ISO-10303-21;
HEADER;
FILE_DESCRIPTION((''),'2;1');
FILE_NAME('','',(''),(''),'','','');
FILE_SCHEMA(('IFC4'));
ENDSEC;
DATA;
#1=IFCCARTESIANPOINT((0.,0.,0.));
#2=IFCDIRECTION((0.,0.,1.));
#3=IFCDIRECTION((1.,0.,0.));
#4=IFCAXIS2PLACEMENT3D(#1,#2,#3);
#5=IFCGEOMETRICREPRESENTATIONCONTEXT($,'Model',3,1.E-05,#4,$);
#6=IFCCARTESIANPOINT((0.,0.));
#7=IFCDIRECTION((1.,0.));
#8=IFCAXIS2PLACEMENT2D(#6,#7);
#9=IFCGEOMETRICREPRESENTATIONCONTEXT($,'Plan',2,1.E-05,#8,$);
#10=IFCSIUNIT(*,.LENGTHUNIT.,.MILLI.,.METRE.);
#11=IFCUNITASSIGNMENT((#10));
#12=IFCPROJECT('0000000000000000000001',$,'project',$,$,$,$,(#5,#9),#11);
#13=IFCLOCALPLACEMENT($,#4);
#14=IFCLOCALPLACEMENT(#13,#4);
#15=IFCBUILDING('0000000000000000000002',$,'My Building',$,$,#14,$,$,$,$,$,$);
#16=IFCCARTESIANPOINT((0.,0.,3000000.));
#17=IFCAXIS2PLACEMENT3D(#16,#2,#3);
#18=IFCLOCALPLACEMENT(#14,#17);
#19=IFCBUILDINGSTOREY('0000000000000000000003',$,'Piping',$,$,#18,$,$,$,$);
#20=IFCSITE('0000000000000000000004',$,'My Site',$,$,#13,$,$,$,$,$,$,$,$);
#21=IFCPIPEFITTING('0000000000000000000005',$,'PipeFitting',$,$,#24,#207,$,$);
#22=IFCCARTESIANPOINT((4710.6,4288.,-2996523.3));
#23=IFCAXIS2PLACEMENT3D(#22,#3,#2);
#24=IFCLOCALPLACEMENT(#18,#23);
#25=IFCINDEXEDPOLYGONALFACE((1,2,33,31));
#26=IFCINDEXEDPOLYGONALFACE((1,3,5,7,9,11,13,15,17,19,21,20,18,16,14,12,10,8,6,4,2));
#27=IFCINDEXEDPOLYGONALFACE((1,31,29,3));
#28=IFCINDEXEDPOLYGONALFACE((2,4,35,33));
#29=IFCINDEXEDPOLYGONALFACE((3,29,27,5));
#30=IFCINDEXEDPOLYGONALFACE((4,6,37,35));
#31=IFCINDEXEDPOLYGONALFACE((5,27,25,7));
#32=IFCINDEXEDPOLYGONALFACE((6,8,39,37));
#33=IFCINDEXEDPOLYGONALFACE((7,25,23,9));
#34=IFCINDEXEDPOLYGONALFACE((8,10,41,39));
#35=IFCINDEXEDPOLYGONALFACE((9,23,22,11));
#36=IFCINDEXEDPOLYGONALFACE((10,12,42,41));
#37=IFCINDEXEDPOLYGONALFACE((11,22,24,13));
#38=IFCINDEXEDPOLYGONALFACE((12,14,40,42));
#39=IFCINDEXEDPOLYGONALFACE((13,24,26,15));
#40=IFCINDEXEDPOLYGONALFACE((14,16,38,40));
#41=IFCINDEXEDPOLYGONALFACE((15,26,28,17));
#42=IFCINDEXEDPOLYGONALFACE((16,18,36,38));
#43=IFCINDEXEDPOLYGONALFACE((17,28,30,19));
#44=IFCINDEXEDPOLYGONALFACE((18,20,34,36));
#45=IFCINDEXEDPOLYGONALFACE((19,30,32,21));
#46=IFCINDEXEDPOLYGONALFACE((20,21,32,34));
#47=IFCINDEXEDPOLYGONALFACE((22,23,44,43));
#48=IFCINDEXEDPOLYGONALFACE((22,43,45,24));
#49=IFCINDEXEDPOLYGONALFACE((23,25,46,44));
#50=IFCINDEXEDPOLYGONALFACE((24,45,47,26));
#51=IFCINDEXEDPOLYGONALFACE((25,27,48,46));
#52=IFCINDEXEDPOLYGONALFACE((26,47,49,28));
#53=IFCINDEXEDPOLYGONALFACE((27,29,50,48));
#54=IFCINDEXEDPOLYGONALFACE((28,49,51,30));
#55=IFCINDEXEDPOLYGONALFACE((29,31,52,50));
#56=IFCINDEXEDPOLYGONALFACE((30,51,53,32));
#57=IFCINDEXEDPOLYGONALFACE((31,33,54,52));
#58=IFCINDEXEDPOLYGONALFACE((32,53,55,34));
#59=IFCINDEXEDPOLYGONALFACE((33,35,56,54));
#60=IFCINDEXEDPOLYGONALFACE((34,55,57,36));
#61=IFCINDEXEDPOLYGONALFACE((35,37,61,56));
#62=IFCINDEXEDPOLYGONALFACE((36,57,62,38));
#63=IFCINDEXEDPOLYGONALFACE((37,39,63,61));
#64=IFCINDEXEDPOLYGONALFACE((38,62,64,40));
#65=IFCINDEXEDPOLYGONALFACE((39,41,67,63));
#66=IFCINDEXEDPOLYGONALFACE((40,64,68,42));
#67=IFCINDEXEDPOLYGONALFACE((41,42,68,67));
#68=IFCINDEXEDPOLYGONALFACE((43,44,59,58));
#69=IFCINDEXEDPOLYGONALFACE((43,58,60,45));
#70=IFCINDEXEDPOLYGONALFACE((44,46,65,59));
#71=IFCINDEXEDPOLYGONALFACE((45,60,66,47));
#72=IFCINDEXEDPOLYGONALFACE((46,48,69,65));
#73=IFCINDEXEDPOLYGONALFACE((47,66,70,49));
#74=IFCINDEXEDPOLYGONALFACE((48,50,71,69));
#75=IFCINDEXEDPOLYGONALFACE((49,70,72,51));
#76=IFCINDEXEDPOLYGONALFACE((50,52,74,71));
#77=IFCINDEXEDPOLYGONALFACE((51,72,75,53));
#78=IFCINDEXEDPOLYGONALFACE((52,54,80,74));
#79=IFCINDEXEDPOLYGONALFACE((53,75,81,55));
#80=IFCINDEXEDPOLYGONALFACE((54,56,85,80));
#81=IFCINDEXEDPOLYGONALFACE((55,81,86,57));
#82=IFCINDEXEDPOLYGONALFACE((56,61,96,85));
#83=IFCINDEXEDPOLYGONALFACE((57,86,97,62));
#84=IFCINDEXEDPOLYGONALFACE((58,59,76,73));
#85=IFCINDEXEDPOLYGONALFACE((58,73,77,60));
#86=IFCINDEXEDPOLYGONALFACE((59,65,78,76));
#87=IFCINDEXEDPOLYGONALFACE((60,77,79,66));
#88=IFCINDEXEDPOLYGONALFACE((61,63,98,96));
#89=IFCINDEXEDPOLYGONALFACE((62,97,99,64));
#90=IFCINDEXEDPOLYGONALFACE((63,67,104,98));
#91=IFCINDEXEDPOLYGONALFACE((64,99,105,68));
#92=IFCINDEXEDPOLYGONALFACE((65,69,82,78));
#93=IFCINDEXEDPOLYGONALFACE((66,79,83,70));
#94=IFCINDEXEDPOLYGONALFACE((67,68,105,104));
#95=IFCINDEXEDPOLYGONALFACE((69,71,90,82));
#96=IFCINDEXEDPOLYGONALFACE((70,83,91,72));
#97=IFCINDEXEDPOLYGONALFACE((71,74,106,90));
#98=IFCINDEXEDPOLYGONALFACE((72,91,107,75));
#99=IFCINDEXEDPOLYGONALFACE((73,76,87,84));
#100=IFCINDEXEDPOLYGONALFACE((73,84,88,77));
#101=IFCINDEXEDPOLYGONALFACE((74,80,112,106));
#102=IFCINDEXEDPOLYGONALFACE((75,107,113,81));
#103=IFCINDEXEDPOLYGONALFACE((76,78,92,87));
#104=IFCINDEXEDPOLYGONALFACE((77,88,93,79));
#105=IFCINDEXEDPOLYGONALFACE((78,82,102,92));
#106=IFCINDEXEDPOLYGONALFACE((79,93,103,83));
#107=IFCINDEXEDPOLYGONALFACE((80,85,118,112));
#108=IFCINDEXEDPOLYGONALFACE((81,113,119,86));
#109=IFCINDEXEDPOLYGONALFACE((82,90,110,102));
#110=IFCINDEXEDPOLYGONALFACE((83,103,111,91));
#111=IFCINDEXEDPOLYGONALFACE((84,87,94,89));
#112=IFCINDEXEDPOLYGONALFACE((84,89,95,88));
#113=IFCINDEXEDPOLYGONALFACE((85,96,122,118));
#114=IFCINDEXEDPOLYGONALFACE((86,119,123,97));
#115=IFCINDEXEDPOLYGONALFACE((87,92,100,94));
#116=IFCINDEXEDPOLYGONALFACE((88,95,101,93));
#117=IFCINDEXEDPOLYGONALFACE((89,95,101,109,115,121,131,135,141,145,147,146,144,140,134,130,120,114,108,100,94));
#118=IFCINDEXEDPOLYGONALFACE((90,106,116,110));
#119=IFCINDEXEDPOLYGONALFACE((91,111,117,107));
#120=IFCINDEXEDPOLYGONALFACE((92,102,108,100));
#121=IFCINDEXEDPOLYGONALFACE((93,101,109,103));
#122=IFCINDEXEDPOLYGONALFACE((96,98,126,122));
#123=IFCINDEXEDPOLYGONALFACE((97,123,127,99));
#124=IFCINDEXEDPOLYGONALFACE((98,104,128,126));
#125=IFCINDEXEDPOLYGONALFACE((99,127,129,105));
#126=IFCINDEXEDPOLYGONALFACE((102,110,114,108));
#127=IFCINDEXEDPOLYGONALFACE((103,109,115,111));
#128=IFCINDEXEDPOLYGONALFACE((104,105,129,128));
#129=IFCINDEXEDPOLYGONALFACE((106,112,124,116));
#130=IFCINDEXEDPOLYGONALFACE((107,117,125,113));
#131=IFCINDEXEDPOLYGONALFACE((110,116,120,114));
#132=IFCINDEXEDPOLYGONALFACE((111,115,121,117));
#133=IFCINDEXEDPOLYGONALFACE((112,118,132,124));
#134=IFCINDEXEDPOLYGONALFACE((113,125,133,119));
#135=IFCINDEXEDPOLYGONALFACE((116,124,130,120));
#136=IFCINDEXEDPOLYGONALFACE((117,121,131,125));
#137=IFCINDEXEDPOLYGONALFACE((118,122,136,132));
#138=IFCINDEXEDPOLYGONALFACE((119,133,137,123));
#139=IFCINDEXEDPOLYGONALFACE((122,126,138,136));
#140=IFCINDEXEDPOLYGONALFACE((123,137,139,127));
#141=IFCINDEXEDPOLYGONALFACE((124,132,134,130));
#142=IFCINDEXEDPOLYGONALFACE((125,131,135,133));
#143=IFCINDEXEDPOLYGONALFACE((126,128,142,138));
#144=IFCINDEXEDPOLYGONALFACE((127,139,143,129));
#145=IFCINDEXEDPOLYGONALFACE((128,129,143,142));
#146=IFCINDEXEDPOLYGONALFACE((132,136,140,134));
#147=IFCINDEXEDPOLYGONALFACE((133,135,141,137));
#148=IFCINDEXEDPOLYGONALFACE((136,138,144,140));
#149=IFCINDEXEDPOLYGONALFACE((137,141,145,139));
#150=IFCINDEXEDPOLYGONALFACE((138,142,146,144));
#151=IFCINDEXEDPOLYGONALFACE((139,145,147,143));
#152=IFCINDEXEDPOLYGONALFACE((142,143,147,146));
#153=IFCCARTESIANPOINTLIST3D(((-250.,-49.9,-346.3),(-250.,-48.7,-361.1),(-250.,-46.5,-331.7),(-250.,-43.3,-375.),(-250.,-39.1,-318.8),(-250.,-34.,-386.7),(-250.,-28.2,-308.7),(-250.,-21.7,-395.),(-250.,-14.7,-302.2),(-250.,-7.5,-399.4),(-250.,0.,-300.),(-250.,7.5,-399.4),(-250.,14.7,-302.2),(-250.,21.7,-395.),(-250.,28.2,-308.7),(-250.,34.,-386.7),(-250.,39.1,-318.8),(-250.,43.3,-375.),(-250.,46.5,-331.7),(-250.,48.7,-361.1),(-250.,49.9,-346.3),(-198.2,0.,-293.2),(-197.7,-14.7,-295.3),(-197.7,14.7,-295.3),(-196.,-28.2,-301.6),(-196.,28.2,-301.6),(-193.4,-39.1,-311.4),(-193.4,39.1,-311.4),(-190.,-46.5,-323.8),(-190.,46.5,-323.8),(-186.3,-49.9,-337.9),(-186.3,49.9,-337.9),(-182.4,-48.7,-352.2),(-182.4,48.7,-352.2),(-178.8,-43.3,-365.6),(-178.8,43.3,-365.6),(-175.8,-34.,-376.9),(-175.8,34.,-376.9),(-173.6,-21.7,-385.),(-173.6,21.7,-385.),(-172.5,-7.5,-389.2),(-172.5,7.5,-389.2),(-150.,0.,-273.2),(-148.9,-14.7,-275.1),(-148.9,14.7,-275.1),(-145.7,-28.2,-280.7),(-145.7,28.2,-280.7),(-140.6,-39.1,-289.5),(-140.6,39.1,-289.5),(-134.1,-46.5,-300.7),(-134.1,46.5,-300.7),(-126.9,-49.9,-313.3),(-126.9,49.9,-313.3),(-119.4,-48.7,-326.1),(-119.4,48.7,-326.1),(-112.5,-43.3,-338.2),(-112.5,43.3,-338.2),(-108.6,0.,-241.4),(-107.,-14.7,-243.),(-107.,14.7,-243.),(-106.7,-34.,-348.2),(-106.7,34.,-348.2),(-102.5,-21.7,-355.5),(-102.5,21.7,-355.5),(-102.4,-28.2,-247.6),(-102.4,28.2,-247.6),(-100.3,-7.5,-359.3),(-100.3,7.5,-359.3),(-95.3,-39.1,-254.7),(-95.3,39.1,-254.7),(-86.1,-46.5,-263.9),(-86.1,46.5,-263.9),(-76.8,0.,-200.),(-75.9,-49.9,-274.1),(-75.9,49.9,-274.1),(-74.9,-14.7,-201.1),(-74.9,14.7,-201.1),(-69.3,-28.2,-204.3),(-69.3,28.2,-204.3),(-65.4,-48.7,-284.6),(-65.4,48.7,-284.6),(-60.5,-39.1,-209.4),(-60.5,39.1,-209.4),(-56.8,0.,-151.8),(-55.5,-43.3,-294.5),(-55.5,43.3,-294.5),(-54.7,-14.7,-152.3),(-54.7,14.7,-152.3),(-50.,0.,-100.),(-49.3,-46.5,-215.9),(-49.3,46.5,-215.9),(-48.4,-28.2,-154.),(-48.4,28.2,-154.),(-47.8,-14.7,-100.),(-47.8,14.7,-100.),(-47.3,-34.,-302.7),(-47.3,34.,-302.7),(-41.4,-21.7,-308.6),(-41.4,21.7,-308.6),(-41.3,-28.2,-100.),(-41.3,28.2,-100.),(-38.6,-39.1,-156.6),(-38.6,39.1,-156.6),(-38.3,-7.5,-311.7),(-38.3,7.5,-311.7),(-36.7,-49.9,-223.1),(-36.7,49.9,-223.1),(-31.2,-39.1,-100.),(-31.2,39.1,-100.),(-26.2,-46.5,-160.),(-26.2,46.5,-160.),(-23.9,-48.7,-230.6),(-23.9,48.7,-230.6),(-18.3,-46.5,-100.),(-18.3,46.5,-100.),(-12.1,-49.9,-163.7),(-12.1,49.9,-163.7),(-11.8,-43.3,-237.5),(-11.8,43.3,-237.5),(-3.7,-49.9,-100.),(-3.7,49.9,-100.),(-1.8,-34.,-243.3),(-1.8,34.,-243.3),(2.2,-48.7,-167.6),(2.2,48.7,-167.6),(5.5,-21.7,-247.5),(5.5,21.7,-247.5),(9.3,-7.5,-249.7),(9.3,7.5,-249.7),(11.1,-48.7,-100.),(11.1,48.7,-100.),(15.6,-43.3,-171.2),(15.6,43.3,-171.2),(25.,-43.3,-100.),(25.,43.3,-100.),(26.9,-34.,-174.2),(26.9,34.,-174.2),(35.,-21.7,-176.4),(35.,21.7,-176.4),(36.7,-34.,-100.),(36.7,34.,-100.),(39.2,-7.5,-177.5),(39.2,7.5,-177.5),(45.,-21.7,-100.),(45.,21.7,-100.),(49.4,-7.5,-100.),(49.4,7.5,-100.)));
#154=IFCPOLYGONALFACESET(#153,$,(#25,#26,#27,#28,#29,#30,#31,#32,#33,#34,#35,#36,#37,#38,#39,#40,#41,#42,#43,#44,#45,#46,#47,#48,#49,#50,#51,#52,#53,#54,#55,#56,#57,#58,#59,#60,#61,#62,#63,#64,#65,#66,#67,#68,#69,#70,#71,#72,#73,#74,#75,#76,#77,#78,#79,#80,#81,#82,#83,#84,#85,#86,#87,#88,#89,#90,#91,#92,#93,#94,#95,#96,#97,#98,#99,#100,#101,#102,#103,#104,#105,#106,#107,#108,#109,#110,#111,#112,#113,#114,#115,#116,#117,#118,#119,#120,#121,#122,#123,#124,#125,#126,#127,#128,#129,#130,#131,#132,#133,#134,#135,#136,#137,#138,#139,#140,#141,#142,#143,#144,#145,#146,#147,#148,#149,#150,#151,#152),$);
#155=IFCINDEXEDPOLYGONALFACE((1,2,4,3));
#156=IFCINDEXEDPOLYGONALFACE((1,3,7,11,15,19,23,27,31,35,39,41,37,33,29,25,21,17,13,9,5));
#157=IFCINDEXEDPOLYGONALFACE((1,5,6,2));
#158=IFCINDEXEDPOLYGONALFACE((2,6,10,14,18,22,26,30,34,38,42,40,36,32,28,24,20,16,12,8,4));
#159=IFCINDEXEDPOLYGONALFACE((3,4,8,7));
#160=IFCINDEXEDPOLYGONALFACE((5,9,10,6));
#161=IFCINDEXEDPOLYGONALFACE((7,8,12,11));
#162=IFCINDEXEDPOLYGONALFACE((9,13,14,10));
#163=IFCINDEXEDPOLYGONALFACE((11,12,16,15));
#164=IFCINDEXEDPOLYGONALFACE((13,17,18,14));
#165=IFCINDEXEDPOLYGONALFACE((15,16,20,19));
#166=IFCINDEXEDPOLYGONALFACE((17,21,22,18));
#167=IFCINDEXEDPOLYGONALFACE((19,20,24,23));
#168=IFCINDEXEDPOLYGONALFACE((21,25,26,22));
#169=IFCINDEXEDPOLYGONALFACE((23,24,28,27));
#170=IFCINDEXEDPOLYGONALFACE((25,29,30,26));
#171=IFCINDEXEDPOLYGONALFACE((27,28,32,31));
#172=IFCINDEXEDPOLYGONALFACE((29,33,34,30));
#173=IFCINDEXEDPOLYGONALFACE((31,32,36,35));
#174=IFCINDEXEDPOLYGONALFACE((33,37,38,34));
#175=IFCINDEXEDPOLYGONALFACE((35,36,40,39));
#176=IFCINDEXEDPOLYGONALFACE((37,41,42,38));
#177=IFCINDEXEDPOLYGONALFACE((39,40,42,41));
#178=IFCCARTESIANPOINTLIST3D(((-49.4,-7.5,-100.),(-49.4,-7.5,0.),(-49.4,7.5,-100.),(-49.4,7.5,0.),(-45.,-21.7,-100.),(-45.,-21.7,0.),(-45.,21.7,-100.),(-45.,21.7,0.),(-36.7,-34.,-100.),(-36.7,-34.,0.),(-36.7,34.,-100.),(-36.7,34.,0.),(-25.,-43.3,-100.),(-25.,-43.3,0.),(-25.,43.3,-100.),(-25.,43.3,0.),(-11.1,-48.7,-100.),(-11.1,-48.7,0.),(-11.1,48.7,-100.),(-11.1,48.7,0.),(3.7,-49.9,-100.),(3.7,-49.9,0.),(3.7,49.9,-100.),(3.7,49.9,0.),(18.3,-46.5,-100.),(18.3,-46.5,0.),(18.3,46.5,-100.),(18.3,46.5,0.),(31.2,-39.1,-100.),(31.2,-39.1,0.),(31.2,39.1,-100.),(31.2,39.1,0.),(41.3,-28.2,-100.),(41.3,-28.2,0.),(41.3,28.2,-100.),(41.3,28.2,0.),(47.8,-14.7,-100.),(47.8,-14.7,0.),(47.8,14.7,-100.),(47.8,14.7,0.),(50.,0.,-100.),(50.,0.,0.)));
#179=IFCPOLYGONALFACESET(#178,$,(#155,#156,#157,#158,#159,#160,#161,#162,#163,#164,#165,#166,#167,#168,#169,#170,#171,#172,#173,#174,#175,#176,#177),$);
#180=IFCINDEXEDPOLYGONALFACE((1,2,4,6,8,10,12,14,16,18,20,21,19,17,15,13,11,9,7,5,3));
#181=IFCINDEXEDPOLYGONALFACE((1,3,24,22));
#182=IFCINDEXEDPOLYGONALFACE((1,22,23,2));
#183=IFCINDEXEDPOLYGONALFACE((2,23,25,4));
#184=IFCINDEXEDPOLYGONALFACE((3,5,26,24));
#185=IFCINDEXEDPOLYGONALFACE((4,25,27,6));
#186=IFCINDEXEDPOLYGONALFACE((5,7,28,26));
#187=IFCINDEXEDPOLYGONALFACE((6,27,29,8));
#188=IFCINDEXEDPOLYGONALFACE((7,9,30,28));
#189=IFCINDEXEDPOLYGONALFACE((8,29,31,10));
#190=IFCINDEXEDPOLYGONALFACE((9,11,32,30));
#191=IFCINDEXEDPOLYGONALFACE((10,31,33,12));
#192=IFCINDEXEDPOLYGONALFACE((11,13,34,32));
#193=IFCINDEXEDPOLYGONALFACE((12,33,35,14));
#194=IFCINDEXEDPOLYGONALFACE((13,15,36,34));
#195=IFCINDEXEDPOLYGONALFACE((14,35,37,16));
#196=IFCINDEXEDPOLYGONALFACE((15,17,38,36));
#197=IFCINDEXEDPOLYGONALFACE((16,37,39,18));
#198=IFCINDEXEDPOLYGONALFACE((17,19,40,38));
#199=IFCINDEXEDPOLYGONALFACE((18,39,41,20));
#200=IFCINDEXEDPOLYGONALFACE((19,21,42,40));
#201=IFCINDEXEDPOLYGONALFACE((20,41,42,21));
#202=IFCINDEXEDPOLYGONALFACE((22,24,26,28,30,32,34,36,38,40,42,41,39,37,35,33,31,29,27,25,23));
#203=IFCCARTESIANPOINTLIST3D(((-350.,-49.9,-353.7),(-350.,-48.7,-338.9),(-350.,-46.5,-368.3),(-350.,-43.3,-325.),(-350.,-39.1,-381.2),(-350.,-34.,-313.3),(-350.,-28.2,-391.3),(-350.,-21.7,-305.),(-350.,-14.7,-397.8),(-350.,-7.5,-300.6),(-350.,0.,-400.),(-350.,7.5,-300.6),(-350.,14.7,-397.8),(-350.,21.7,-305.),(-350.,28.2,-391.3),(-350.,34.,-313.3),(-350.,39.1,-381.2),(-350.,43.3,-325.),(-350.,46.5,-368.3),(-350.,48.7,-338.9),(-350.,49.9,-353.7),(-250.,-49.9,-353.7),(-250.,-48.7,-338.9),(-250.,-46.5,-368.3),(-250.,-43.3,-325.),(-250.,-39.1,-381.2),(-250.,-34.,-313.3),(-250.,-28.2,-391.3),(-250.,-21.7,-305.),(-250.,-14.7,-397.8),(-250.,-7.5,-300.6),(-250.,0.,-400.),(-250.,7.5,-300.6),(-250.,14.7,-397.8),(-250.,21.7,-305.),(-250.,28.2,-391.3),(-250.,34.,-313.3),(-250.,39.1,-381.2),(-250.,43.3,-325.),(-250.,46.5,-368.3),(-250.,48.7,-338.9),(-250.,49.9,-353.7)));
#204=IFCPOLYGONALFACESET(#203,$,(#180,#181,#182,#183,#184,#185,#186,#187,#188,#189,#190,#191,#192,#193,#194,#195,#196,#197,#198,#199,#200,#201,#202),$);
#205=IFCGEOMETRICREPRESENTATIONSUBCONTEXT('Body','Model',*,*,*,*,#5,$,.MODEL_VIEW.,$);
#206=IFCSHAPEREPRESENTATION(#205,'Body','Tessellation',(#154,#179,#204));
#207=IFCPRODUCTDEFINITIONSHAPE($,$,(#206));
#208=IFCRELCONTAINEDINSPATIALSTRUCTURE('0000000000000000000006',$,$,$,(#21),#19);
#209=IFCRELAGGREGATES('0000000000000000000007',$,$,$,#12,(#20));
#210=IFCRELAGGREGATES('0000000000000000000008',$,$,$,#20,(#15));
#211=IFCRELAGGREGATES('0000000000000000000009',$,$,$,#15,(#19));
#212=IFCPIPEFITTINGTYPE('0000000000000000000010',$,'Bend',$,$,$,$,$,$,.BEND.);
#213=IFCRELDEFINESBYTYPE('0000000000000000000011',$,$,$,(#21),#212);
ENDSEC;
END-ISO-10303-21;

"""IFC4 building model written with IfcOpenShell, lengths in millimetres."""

from ifc_helpers import new_model, entity, si_unit, frame, origin_with_axes, origin_2d_with_axis, place, context, subcontext, project, spatial, circle, extrude, source, transform, mapped, type_object, type_shapes, element, save


model = new_model("IFC4")

# Units and contexts
model_context = context("Model", 3, precision=1e-05, world=origin_with_axes())
plan_context = context("Plan", 2, precision=1e-05, world=origin_2d_with_axis())
body_context = subcontext(model_context, "Body", "Model", "MODEL_VIEW")
ifc_project = project(units=[si_unit("LENGTHUNIT", "METRE", prefix="MILLI")], contexts=[model_context, plan_context])

# Site, building, storey
site_placement = place(None, origin_with_axes())
site = spatial("IfcSite", under=ifc_project, at=site_placement, Name="My Site")
building_placement = place(site_placement, origin_with_axes())
building = spatial("IfcBuilding", under=site, at=building_placement, Name="My Building")
storey_placement = place(building_placement, frame((0.0, 0.0, 3000000.0), z_axis=(0.0, 0.0, 1.0), x_axis=(1.0, 0.0, 0.0)))
storey = spatial("IfcBuildingStorey", under=building, at=storey_placement, Name="Piping")

# Shared definitions
pipe_fitting_type_1 = type_object("IfcPipeFittingType", Name="Bend", PredefinedType="BEND")
shared_shape_1 = source(origin_with_axes(), body_context, "Body", "SolidModel", [
    entity("IfcSweptDiskSolid", entity("IfcIndexedPolyCurve", entity("IfcCartesianPointList3D", [[0.0, 0.0, -100.0], [-73.2, 0.0, -276.8], [-250.0, 0.0, -350.0]]), [entity("IfcArcIndex", [1, 2, 3])]), 50.0),
    extrude(circle(Radius=50.0), origin_with_axes(), (0.0, 0.0, -1.0), 100.0),
    extrude(circle(Radius=50.0), frame((-250.0, 0.0, -350.0), z_axis=(-1.0, 0.0, 0.0), x_axis=(0.0, 0.0, -1.0)), (0.0, 0.0, 1.0), 100.0),
])
type_shapes(pipe_fitting_type_1, [shared_shape_1])

# Pipe fitting
for number, where, z_axis, x_axis, name in (
    (1, (4710.6, 4288.0, -2996523.3), (1.0, 0.0, 0.0), (0.0, 0.0, 1.0), "PipeFitting"),
):
    element("IfcPipeFitting", number, at=place(storey_placement, frame(where, z_axis=z_axis, x_axis=x_axis)), inside=storey, type_object=pipe_fitting_type_1, Name=name, context=body_context, shape_type="MappedRepresentation", body=[
        mapped(shared_shape_1, transform((0.0, 0.0, 0.0), x_axis=(1.0, 0.0, 0.0), y_axis=(0.0, 1.0, 0.0), z_axis=(0.0, 0.0, 1.0), scale=1.0)),
    ])

save(model, "model.ifc")
